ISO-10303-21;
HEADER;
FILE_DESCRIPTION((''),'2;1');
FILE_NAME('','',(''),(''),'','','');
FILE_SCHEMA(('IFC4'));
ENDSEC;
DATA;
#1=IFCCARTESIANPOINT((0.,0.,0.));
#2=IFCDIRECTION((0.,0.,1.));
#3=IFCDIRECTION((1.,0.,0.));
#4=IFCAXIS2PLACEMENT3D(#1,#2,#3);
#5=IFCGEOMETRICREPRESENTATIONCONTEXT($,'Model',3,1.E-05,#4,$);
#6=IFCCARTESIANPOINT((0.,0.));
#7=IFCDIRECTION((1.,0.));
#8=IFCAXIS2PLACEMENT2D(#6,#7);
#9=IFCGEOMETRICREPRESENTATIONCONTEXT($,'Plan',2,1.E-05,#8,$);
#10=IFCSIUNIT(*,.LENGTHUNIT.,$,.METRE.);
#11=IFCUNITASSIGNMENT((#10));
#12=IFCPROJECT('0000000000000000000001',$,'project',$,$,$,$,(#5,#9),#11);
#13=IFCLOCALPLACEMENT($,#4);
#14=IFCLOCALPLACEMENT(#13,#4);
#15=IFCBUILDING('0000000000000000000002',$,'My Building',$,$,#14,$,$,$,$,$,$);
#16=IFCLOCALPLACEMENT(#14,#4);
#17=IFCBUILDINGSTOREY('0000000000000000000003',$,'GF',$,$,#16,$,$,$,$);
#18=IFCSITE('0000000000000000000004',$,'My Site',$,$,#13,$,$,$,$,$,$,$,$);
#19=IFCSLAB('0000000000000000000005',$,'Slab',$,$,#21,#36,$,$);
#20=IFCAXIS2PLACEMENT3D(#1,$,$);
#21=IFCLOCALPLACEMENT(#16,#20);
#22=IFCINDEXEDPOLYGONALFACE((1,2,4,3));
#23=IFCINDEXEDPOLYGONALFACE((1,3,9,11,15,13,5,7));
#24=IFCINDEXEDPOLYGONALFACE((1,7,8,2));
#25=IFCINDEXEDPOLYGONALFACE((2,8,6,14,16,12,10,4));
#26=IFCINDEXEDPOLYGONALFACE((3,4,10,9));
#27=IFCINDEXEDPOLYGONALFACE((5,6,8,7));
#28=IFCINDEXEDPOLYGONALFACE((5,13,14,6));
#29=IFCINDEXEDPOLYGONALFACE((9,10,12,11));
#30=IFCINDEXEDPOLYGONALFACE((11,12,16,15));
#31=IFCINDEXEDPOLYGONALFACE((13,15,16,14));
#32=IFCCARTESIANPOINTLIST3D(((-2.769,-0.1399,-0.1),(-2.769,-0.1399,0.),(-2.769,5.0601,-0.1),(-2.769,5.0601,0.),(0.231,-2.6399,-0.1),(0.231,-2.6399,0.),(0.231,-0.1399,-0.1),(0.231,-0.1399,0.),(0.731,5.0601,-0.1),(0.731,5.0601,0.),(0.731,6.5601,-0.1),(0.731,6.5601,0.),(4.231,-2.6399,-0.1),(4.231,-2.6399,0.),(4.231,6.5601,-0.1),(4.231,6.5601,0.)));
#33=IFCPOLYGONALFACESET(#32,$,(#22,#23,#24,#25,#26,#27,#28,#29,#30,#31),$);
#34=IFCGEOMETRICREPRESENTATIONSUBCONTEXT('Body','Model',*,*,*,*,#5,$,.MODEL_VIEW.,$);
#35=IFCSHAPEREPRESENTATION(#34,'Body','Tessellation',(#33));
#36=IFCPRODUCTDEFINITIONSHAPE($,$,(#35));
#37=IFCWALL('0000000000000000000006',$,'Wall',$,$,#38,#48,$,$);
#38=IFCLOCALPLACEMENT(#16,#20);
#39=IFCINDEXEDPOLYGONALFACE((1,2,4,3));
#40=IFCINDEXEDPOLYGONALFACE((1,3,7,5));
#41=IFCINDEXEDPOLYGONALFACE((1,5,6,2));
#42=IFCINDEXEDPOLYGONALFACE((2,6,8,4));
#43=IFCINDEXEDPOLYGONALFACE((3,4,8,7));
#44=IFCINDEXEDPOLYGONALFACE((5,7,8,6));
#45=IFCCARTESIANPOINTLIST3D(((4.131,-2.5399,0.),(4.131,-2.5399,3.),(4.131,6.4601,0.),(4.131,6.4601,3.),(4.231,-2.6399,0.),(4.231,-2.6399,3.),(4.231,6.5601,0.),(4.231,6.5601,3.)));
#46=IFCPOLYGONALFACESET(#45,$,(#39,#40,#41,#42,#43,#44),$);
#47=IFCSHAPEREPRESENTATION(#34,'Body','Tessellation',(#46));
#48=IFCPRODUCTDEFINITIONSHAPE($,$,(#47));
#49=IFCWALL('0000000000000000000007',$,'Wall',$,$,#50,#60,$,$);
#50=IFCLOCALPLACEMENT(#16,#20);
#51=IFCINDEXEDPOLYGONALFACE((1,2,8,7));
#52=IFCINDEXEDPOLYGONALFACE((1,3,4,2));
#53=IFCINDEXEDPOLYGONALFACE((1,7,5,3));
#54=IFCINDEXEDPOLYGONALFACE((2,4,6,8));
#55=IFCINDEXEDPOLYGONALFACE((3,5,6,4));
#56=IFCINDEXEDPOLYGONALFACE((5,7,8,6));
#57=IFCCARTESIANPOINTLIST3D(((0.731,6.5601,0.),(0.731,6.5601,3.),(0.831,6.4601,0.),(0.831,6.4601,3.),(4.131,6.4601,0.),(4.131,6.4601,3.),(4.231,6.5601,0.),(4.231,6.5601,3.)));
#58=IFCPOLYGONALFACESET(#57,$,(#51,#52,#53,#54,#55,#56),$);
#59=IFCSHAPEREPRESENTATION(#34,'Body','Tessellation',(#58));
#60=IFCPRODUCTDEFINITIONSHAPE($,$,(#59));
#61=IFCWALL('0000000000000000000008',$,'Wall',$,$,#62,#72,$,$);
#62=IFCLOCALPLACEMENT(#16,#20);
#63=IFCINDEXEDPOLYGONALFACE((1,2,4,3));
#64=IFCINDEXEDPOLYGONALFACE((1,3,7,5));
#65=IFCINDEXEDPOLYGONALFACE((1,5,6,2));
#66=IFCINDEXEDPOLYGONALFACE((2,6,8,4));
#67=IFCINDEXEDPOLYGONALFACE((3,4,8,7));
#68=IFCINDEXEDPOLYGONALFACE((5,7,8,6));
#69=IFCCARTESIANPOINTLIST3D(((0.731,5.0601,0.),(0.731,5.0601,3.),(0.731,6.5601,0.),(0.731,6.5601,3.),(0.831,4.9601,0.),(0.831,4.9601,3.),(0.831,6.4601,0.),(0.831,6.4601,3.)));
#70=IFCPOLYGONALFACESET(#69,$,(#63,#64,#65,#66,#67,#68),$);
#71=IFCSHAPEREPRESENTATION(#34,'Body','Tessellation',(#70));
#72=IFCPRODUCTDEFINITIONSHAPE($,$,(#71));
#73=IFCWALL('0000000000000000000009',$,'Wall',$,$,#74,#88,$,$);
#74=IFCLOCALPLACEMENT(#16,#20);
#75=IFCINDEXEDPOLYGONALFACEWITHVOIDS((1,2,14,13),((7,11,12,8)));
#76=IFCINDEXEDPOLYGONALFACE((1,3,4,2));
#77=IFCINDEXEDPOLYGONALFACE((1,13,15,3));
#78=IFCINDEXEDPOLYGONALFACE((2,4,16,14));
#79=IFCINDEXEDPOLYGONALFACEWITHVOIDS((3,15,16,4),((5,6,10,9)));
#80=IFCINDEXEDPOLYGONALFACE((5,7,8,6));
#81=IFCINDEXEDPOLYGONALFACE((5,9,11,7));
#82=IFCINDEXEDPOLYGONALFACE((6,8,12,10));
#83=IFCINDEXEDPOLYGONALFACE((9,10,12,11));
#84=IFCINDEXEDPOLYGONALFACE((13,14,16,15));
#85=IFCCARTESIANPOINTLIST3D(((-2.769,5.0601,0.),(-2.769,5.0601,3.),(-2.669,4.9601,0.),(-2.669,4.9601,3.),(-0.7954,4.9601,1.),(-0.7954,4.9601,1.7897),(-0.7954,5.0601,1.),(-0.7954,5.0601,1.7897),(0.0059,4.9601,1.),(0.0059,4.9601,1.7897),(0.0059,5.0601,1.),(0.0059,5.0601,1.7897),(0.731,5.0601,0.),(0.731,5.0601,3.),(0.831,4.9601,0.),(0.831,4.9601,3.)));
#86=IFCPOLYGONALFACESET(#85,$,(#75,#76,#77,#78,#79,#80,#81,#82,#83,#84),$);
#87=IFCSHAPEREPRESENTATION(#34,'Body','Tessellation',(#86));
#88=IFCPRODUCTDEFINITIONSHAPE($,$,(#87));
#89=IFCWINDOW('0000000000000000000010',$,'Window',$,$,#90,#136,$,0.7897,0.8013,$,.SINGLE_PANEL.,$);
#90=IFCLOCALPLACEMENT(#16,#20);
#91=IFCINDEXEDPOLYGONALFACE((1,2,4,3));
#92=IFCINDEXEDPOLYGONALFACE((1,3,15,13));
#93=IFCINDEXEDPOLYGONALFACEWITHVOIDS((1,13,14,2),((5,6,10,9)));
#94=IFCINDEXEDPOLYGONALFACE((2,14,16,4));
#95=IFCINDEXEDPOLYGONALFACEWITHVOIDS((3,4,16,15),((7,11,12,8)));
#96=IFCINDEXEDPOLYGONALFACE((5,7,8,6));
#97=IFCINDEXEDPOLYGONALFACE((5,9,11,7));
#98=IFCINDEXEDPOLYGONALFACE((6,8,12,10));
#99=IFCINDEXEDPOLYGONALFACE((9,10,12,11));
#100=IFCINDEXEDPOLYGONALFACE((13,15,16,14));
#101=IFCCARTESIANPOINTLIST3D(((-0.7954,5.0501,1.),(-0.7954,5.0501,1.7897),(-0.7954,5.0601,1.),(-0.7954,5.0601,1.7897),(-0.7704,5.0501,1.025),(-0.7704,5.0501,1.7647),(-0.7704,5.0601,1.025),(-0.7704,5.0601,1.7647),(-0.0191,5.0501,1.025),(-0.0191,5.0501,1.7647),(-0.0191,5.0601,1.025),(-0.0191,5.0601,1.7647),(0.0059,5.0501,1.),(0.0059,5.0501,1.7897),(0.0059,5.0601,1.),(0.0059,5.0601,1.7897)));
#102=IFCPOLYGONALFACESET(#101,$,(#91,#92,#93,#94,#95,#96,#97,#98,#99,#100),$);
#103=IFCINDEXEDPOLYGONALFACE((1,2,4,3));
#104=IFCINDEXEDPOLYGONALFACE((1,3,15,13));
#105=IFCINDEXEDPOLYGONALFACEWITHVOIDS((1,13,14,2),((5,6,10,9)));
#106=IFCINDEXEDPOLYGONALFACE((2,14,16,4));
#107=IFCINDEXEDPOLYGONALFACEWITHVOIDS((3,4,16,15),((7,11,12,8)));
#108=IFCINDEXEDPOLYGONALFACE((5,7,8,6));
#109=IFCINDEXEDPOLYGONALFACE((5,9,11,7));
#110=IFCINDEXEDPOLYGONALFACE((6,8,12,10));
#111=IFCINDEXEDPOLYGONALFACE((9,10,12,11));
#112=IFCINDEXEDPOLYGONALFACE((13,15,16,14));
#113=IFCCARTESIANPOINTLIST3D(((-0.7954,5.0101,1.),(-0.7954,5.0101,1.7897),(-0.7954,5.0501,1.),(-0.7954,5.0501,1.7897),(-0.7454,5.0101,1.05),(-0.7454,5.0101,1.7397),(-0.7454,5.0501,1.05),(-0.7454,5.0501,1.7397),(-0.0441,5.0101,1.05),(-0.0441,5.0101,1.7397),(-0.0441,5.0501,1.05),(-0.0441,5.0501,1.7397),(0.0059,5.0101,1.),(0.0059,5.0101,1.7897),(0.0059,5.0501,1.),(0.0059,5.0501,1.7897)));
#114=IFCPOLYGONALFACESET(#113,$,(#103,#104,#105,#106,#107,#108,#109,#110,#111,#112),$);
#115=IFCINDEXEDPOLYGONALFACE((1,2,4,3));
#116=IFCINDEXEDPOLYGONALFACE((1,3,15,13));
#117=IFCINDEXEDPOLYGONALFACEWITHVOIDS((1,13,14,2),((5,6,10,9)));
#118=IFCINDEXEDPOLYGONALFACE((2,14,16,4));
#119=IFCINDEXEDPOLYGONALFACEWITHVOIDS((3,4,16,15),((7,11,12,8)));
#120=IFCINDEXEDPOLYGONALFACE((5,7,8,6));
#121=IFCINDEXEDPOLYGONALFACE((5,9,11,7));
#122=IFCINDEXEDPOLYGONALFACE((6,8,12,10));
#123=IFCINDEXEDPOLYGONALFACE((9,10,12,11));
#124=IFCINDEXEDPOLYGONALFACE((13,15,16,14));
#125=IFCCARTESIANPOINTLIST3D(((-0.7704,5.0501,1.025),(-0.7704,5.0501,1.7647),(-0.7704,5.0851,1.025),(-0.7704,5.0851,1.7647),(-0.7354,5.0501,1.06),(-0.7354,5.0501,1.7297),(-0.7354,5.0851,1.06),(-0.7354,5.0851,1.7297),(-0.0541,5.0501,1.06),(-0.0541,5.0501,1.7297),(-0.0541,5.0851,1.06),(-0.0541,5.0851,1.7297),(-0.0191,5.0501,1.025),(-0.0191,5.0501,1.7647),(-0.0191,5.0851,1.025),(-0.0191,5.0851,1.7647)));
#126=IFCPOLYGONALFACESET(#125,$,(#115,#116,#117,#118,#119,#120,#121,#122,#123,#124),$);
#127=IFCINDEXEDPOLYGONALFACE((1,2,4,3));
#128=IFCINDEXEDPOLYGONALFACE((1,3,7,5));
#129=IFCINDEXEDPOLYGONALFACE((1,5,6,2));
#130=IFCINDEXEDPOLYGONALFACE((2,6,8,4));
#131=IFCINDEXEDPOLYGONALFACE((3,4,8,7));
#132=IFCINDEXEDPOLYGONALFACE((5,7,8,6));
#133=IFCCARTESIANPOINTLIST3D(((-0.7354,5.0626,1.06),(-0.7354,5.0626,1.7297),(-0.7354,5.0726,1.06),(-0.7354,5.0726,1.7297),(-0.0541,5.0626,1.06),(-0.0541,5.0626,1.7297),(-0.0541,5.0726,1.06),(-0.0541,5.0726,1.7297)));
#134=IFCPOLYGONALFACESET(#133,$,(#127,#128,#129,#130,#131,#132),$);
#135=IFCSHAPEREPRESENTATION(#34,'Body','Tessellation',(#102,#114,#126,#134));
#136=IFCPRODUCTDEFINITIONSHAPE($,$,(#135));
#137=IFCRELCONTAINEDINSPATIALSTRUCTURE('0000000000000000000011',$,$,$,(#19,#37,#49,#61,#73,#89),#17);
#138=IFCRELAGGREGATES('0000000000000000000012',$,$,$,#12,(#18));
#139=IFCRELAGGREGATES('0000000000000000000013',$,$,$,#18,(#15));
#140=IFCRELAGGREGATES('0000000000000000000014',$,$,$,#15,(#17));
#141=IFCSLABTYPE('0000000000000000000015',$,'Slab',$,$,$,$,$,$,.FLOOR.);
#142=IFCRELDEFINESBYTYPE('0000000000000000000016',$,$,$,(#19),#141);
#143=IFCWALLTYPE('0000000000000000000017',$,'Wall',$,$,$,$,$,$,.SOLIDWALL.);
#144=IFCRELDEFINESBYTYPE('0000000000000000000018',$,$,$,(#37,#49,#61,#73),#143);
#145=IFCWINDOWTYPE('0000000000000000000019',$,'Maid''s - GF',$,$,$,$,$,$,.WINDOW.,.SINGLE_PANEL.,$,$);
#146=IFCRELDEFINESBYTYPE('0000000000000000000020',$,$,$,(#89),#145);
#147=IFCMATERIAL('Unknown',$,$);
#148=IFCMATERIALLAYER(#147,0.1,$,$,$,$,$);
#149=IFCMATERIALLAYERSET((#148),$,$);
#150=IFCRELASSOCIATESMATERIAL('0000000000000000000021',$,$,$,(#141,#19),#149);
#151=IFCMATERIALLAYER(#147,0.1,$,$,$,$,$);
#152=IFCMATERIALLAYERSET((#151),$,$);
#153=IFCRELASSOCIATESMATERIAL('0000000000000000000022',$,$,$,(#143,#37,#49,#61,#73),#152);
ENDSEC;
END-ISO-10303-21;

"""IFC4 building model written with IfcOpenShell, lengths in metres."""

from ifc_helpers import new_model, entity, si_unit, frame, origin_with_axes, origin_2d_with_axis, place, context, subcontext, project, spatial, line, indexed_curve, outline, extrude, shape, source, transform, mapped, material, layer, layer_set, layer_usage, type_object, type_shapes, element, fill, save


model = new_model("IFC4")

# Units and contexts
model_context = context("Model", 3, precision=1e-05, world=origin_with_axes())
plan_context = context("Plan", 2, precision=1e-05, world=origin_2d_with_axis())
body_context_1 = subcontext(model_context, "Body", "Model", "MODEL_VIEW")
body_context_2 = subcontext(plan_context, "Body", "Plan", "PLAN_VIEW")
ifc_project = project(units=[si_unit("LENGTHUNIT", "METRE")], contexts=[model_context, plan_context])

# Site, building, storey
site_placement = place(None, origin_with_axes())
site = spatial("IfcSite", under=ifc_project, at=site_placement, Name="My Site")
building_placement = place(site_placement, origin_with_axes())
building = spatial("IfcBuilding", under=site, at=building_placement, Name="My Building")
storey_placement = place(building_placement, origin_with_axes())
storey = spatial("IfcBuildingStorey", under=building, at=storey_placement, Name="GF")

# Slab
ifc_material = material(Name="Unknown")
ifc_layer_1 = layer(ifc_material, 0.1)
ifc_layer_set_1 = layer_set([ifc_layer_1])
ifc_layer_usage_1 = layer_usage(ifc_layer_set_1, "AXIS3", "POSITIVE", -0.1)
slab_type = type_object("IfcSlabType", Name="Slab", PredefinedType="FLOOR", material=ifc_layer_set_1)
slab_placement = place(storey_placement, frame((4.231, 6.5601, 0.0), z_axis=(0.0, 0.0, 1.0), x_axis=(1.0, 0.0, 0.0)))
element("IfcSlab", 1, at=slab_placement, inside=storey, type_object=slab_type, material=ifc_layer_usage_1, Name="Slab", context=body_context_1, shape_type="SweptSolid", body=[
    extrude(outline(indexed_curve([(0.0, 0.0), (-3.5, 0.0), (-3.5, -1.5), (-7.0, -1.5), (-7.0, -6.7), (-4.0, -6.7), (-4.0, -9.2), (0.0, -9.2), (0.0, 0.0)])), frame((0.0, 0.0, -0.1), z_axis=(0.0, 0.0, 1.0), x_axis=(1.0, 0.0, 0.0)), (0.0, 0.0, 1.0), 0.1),
])

# Shared definitions
ifc_layer_2 = layer(ifc_material, 0.1)
ifc_layer_set_2 = layer_set([ifc_layer_2])
wall_type = type_object("IfcWallType", Name="Wall", PredefinedType="SOLIDWALL", material=ifc_layer_set_2)

# Walls
ifc_layer_usage_2 = layer_usage(ifc_layer_set_2, "AXIS2", "POSITIVE", 0.0)
wall_1_placement = place(storey_placement, frame((4.231, -2.6399, 0.0), z_axis=(0.0, 0.0, 1.0), x_axis=(0.0, 1.0, 0.0)))
element("IfcWall", 2, at=wall_1_placement, inside=storey, type_object=wall_type, material=ifc_layer_usage_2, Name="Wall", context=body_context_1, shape_type="SweptSolid", body=[
    extrude(outline(indexed_curve([(0.0, 0.0), (0.1, 0.1), (9.1, 0.1), (9.2, 0.0)], segments=[line(1, 2, 3, 4, 1)])), origin_with_axes(), (0.0, 0.0, 1.0), 3.0),
])
ifc_layer_usage_3 = layer_usage(ifc_layer_set_2, "AXIS2", "POSITIVE", 0.0)
wall_2_placement = place(storey_placement, frame((4.231, 6.5601, 0.0), z_axis=(0.0, 0.0, 1.0), x_axis=(-1.0, 0.0, 0.0)))
element("IfcWall", 3, at=wall_2_placement, inside=storey, type_object=wall_type, material=ifc_layer_usage_3, Name="Wall", context=body_context_1, shape_type="SweptSolid", body=[
    extrude(outline(indexed_curve([(0.0, 0.0), (0.1, 0.1), (3.4, 0.1), (3.5, 0.0)], segments=[line(1, 2, 3, 4, 1)])), origin_with_axes(), (0.0, 0.0, 1.0), 3.0),
])
ifc_layer_usage_4 = layer_usage(ifc_layer_set_2, "AXIS2", "POSITIVE", 0.0)
wall_3_placement = place(storey_placement, frame((0.731, 6.5601, 0.0), z_axis=(0.0, 0.0, 1.0), x_axis=(0.0, -1.0, 0.0)))
element("IfcWall", 4, at=wall_3_placement, inside=storey, type_object=wall_type, material=ifc_layer_usage_4, Name="Wall", context=body_context_1, shape_type="SweptSolid", body=[
    extrude(outline(indexed_curve([(0.0, 0.0), (0.1, 0.1), (1.6, 0.1), (1.5, 0.0)], segments=[line(1, 2, 3, 4, 1)])), origin_with_axes(), (0.0, 0.0, 1.0), 3.0),
])

# Wall, opening, window
ifc_layer_usage_5 = layer_usage(ifc_layer_set_2, "AXIS2", "POSITIVE", 0.0)
wall_4_placement = place(storey_placement, frame((0.731, 5.0601, 0.0), z_axis=(0.0, 0.0, 1.0), x_axis=(-1.0, 0.0, 0.0)))
wall_4 = element("IfcWall", 5, at=wall_4_placement, inside=storey, type_object=wall_type, material=ifc_layer_usage_5, Name="Wall", context=body_context_1, shape_type="SweptSolid", body=[
    extrude(outline(indexed_curve([(0.0, 0.0), (-0.1, 0.1), (3.4, 0.1), (3.5, 0.0)], segments=[line(1, 2, 3, 4, 1)])), origin_with_axes(), (0.0, 0.0, 1.0), 3.0),
])
shared_shape_1 = source(origin_with_axes(), body_context_1, "Body", "SweptSolid", [
    extrude(outline(indexed_curve([(0.0, 0.0), (0.8013, 0.0), (0.8013, 0.7897), (0.0, 0.7897)], segments=[line(1, 2, 3, 4, 1)])), frame((0.0, -0.6, 0.0), z_axis=(0.0, -1.0, 0.0), x_axis=(1.0, 0.0, 0.0)), (0.0, 0.0, -1.0), 1.2),
])
opening_1_placement = place(wall_4_placement, frame((1.5264, 0.1, 1.0), z_axis=(0.0, 0.0, 1.0), x_axis=(-1.0, 0.0, 0.0)))
opening_1 = element("IfcOpeningElement", 6, at=opening_1_placement, cuts=wall_4, PredefinedType="OPENING", context=body_context_1, shape_type="MappedRepresentation", body=[
    mapped(shared_shape_1, transform((0.0, 0.0, 0.0), x_axis=(1.0, 0.0, 0.0), y_axis=(0.0, 1.0, 0.0), z_axis=(0.0, 0.0, 1.0), scale=1.0)),
])
window_type_1 = type_object("IfcWindowType", Name="Maid's - GF", PartitioningType="SINGLE_PANEL", PredefinedType="WINDOW")
shared_shape_2 = source(origin_with_axes(), body_context_1, "Body", "SweptSolid", [
    extrude(outline(indexed_curve([(0.0, 0.0), (0.8013, 0.0), (0.8013, 0.7897), (0.0, 0.7897)], segments=[line(1, 2, 3, 4, 1)]), holes=[indexed_curve([(0.025, 0.025), (0.7763, 0.025), (0.7763, 0.7647), (0.025, 0.7647)], segments=[line(1, 2, 3, 4, 1)])]), frame((0.0, 0.09, 0.0), z_axis=(0.0, -1.0, 0.0), x_axis=(1.0, 0.0, 0.0)), (0.0, 0.0, -1.0), 0.01),
    extrude(outline(indexed_curve([(0.0, 0.0), (0.8013, 0.0), (0.8013, 0.7897), (0.0, 0.7897)], segments=[line(1, 2, 3, 4, 1)]), holes=[indexed_curve([(0.05, 0.05), (0.7513, 0.05), (0.7513, 0.7397), (0.05, 0.7397)], segments=[line(1, 2, 3, 4, 1)])]), frame((0.0, 0.05, 0.0), z_axis=(0.0, -1.0, 0.0), x_axis=(1.0, 0.0, 0.0)), (0.0, 0.0, -1.0), 0.04),
    extrude(outline(indexed_curve([(0.0, 0.0), (0.7513, 0.0), (0.7513, 0.7397), (0.0, 0.7397)], segments=[line(1, 2, 3, 4, 1)]), holes=[indexed_curve([(0.035, 0.035), (0.7163, 0.035), (0.7163, 0.7047), (0.035, 0.7047)], segments=[line(1, 2, 3, 4, 1)])]), frame((0.025, 0.09, 0.025), z_axis=(0.0, -1.0, 0.0), x_axis=(1.0, 0.0, 0.0)), (0.0, 0.0, -1.0), 0.035),
    extrude(outline(indexed_curve([(0.035, 0.035), (0.7163, 0.035), (0.7163, 0.7047), (0.035, 0.7047)], segments=[line(1, 2, 3, 4, 1)])), frame((0.025, 0.1025, 0.025), z_axis=(0.0, -1.0, 0.0), x_axis=(1.0, 0.0, 0.0)), (0.0, 0.0, -1.0), 0.01),
])
shared_shape_3 = source(origin_with_axes(), body_context_2, "Body", "Curve2D", [
    entity("IfcIndexedPolyCurve", entity("IfcCartesianPointList2D", [[0.05, 0.05], [0.7513, 0.05]])),
    entity("IfcIndexedPolyCurve", entity("IfcCartesianPointList2D", [[0.0, 0.1], [0.025, 0.1], [0.025, 0.09], [0.05, 0.09], [0.05, 0.05], [0.0, 0.05]]), [entity("IfcLineIndex", [1, 2, 3, 4, 5, 6, 1])]),
    entity("IfcIndexedPolyCurve", entity("IfcCartesianPointList2D", [[0.8013, 0.1], [0.7763, 0.1], [0.7763, 0.09], [0.7513, 0.09], [0.7513, 0.05], [0.8013, 0.05]]), [entity("IfcLineIndex", [1, 2, 3, 4, 5, 6, 1])]),
    entity("IfcIndexedPolyCurve", entity("IfcCartesianPointList2D", [[0.025, 0.09], [0.06, 0.09], [0.06, 0.125], [0.025, 0.125]]), [entity("IfcLineIndex", [1, 2, 3, 4, 1])]),
    entity("IfcIndexedPolyCurve", entity("IfcCartesianPointList2D", [[0.7763, 0.09], [0.7413, 0.09], [0.7413, 0.125], [0.7763, 0.125]]), [entity("IfcLineIndex", [1, 2, 3, 4, 1])]),
    entity("IfcIndexedPolyCurve", entity("IfcCartesianPointList2D", [[0.06, 0.09], [0.7413, 0.09]])),
    entity("IfcIndexedPolyCurve", entity("IfcCartesianPointList2D", [[0.06, 0.125], [0.7413, 0.125]])),
    entity("IfcIndexedPolyCurve", entity("IfcCartesianPointList2D", [[0.06, 0.1075], [0.7413, 0.1075]])),
])
type_shapes(window_type_1, [shared_shape_2, shared_shape_3])
window_1_placement = place(opening_1_placement, frame((0.0, 0.0, 0.0), z_axis=(0.0, 0.0, 1.0), x_axis=(1.0, 0.0, 0.0)))
window_1 = element("IfcWindow", 7, at=window_1_placement, inside=storey, type_object=window_type_1, Name="Window", OverallHeight=0.7897, OverallWidth=0.8013, PartitioningType="SINGLE_PANEL", shapes=[
    shape(body_context_1, "Body", "MappedRepresentation", [mapped(shared_shape_2, transform((0.0, 0.0, 0.0), x_axis=(1.0, 0.0, 0.0), y_axis=(0.0, 1.0, 0.0), z_axis=(0.0, 0.0, 1.0), scale=1.0))]),
    shape(body_context_2, "Body", "MappedRepresentation", [mapped(shared_shape_3, transform((0.0, 0.0, 0.0), x_axis=(1.0, 0.0, 0.0), y_axis=(0.0, 1.0, 0.0), z_axis=(0.0, 0.0, 1.0), scale=1.0))]),
])
fill(opening_1, window_1)

save(model, "model.ifc")
